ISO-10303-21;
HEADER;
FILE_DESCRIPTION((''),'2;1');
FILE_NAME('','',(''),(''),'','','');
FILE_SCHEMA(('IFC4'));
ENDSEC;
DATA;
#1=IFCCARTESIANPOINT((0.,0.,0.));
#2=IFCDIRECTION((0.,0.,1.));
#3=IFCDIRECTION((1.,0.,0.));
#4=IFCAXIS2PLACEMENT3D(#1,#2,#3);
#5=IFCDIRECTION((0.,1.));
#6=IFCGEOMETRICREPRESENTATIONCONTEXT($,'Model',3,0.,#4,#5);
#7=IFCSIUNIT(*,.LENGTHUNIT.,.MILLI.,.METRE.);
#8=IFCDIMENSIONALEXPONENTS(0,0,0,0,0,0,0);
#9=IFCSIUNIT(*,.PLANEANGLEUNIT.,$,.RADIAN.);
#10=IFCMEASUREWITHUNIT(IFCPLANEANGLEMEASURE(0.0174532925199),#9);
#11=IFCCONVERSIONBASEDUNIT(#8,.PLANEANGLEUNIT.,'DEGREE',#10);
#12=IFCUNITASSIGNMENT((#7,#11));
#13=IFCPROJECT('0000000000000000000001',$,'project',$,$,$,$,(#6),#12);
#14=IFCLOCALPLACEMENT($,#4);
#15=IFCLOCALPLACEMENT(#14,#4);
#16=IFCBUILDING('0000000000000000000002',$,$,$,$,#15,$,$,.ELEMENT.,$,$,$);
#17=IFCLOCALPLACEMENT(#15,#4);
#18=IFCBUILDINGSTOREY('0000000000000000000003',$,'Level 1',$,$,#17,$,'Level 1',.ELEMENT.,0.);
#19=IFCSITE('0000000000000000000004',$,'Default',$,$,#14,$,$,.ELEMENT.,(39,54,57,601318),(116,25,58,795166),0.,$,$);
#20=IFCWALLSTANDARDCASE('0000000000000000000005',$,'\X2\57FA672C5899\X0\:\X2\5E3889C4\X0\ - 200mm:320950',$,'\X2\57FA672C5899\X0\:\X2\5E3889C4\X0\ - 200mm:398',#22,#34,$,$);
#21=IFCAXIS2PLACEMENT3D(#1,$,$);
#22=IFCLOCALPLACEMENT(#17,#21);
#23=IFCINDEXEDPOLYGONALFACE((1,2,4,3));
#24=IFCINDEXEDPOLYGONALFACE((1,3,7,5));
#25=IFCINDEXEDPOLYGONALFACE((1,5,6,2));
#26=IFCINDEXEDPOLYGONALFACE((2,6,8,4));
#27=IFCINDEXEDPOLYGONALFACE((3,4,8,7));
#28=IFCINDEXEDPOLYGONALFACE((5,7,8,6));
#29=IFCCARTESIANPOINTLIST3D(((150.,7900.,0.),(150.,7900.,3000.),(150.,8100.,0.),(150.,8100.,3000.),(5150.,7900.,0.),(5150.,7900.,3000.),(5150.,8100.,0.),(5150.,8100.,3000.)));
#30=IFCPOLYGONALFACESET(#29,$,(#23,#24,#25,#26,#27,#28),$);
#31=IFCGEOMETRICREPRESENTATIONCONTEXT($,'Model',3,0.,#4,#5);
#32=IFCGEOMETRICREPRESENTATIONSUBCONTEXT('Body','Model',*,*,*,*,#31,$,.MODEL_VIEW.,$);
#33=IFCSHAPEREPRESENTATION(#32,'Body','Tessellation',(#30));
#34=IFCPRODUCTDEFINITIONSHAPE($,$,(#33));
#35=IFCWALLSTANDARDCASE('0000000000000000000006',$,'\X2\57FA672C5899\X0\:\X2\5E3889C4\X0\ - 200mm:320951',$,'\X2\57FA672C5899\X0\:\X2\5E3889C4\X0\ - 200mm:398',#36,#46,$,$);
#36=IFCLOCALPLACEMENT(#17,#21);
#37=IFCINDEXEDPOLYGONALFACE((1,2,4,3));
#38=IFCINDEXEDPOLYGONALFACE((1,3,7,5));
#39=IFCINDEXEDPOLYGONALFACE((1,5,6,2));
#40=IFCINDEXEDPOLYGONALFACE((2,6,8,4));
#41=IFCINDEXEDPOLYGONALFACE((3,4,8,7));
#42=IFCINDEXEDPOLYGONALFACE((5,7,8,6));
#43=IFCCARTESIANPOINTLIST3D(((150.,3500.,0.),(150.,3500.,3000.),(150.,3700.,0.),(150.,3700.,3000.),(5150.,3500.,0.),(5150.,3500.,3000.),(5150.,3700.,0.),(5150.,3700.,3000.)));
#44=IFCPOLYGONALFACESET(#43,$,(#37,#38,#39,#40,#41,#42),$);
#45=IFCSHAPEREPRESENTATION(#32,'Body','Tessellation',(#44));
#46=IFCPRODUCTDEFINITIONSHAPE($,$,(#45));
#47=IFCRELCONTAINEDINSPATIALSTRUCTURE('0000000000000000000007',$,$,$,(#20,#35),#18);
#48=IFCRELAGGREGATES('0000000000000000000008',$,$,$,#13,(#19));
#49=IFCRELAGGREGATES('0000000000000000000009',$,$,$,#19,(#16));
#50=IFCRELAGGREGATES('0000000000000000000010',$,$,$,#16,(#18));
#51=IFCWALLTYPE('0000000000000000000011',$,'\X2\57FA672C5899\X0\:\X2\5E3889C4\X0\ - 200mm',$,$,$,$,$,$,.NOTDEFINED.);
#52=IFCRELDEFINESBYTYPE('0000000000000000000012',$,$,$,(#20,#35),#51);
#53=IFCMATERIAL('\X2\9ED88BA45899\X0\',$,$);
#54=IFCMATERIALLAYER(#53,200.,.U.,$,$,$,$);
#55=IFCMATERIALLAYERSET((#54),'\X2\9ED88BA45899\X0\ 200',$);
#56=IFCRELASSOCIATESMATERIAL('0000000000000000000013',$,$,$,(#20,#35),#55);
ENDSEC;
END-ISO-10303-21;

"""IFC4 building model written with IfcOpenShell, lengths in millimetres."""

from ifc_helpers import new_model, entity, si_unit, converted_unit, direction, frame, origin_with_axes, place, context, subcontext, project, spatial, polyline, outline, extrude, material, layer, layer_set, layer_usage, type_object, element, save


model = new_model("IFC4")

# Units and contexts
model_context_1 = context("Model", 3, precision=0.0, world=origin_with_axes(), true_north=direction((0.0, 1.0)))
model_context_2 = context("Model", 3, precision=0.0, world=origin_with_axes(), true_north=direction((0.0, 1.0)))
body_context = subcontext(model_context_2, "Body", "Model", "MODEL_VIEW")
ifc_project = project(units=[si_unit("LENGTHUNIT", "METRE", prefix="MILLI"), converted_unit("PLANEANGLEUNIT", "DEGREE", entity("IfcPlaneAngleMeasure", 0.0174532925199), si_unit("PLANEANGLEUNIT", "RADIAN"), dimensions=[0, 0, 0, 0, 0, 0, 0])], contexts=[model_context_1])

# Site, building, storey
site_placement = place(None, origin_with_axes())
site = spatial("IfcSite", under=ifc_project, at=site_placement, Name="Default", CompositionType="ELEMENT", RefLatitude=(39, 54, 57, 601318), RefLongitude=(116, 25, 58, 795166), RefElevation=0.0)
building_placement = place(site_placement, origin_with_axes())
building = spatial("IfcBuilding", under=site, at=building_placement, CompositionType="ELEMENT")
storey_placement = place(building_placement, origin_with_axes())
storey = spatial("IfcBuildingStorey", under=building, at=storey_placement, Name="Level 1", LongName="Level 1", CompositionType="ELEMENT", Elevation=0.0)

# Shared definitions
ifc_material = material(Name="默认墙")
ifc_layer = layer(ifc_material, 200.0, ventilated="UNKNOWN")
ifc_layer_set = layer_set([ifc_layer], Name="默认墙 200")
wall_type = type_object("IfcWallType", Name="基本墙:常规 - 200mm", PredefinedType="NOTDEFINED")

# Walls
ifc_layer_usage_1 = layer_usage(ifc_layer_set, "AXIS2", "POSITIVE", -100.0)
wall_1_placement = place(storey_placement, frame((150.0, 8000.0, 0.0), z_axis=(0.0, 0.0, 1.0), x_axis=(1.0, 0.0, 0.0)))
element("IfcWallStandardCase", 1, at=wall_1_placement, inside=storey, type_object=wall_type, material=ifc_layer_usage_1, Name="基本墙:常规 - 200mm:320950", ObjectType="基本墙:常规 - 200mm:398", context=body_context, shape_type="SweptSolid", body=[
    extrude(outline(polyline([(0.0, -100.0), (5000.0, -100.0), (5000.0, 100.0), (0.0, 100.0), (0.0, -100.0)])), origin_with_axes(), (0.0, 0.0, 1.0), 3000.0),
])
ifc_layer_usage_2 = layer_usage(ifc_layer_set, "AXIS2", "POSITIVE", -100.0)
wall_2_placement = place(storey_placement, frame((150.0, 3600.0, 0.0), z_axis=(0.0, 0.0, 1.0), x_axis=(1.0, 0.0, 0.0)))
element("IfcWallStandardCase", 2, at=wall_2_placement, inside=storey, type_object=wall_type, material=ifc_layer_usage_2, Name="基本墙:常规 - 200mm:320951", ObjectType="基本墙:常规 - 200mm:398", context=body_context, shape_type="SweptSolid", body=[
    extrude(outline(polyline([(0.0, -100.0), (5000.0, -100.0), (5000.0, 100.0), (0.0, 100.0), (0.0, -100.0)])), origin_with_axes(), (0.0, 0.0, 1.0), 3000.0),
])

save(model, "model.ifc")
